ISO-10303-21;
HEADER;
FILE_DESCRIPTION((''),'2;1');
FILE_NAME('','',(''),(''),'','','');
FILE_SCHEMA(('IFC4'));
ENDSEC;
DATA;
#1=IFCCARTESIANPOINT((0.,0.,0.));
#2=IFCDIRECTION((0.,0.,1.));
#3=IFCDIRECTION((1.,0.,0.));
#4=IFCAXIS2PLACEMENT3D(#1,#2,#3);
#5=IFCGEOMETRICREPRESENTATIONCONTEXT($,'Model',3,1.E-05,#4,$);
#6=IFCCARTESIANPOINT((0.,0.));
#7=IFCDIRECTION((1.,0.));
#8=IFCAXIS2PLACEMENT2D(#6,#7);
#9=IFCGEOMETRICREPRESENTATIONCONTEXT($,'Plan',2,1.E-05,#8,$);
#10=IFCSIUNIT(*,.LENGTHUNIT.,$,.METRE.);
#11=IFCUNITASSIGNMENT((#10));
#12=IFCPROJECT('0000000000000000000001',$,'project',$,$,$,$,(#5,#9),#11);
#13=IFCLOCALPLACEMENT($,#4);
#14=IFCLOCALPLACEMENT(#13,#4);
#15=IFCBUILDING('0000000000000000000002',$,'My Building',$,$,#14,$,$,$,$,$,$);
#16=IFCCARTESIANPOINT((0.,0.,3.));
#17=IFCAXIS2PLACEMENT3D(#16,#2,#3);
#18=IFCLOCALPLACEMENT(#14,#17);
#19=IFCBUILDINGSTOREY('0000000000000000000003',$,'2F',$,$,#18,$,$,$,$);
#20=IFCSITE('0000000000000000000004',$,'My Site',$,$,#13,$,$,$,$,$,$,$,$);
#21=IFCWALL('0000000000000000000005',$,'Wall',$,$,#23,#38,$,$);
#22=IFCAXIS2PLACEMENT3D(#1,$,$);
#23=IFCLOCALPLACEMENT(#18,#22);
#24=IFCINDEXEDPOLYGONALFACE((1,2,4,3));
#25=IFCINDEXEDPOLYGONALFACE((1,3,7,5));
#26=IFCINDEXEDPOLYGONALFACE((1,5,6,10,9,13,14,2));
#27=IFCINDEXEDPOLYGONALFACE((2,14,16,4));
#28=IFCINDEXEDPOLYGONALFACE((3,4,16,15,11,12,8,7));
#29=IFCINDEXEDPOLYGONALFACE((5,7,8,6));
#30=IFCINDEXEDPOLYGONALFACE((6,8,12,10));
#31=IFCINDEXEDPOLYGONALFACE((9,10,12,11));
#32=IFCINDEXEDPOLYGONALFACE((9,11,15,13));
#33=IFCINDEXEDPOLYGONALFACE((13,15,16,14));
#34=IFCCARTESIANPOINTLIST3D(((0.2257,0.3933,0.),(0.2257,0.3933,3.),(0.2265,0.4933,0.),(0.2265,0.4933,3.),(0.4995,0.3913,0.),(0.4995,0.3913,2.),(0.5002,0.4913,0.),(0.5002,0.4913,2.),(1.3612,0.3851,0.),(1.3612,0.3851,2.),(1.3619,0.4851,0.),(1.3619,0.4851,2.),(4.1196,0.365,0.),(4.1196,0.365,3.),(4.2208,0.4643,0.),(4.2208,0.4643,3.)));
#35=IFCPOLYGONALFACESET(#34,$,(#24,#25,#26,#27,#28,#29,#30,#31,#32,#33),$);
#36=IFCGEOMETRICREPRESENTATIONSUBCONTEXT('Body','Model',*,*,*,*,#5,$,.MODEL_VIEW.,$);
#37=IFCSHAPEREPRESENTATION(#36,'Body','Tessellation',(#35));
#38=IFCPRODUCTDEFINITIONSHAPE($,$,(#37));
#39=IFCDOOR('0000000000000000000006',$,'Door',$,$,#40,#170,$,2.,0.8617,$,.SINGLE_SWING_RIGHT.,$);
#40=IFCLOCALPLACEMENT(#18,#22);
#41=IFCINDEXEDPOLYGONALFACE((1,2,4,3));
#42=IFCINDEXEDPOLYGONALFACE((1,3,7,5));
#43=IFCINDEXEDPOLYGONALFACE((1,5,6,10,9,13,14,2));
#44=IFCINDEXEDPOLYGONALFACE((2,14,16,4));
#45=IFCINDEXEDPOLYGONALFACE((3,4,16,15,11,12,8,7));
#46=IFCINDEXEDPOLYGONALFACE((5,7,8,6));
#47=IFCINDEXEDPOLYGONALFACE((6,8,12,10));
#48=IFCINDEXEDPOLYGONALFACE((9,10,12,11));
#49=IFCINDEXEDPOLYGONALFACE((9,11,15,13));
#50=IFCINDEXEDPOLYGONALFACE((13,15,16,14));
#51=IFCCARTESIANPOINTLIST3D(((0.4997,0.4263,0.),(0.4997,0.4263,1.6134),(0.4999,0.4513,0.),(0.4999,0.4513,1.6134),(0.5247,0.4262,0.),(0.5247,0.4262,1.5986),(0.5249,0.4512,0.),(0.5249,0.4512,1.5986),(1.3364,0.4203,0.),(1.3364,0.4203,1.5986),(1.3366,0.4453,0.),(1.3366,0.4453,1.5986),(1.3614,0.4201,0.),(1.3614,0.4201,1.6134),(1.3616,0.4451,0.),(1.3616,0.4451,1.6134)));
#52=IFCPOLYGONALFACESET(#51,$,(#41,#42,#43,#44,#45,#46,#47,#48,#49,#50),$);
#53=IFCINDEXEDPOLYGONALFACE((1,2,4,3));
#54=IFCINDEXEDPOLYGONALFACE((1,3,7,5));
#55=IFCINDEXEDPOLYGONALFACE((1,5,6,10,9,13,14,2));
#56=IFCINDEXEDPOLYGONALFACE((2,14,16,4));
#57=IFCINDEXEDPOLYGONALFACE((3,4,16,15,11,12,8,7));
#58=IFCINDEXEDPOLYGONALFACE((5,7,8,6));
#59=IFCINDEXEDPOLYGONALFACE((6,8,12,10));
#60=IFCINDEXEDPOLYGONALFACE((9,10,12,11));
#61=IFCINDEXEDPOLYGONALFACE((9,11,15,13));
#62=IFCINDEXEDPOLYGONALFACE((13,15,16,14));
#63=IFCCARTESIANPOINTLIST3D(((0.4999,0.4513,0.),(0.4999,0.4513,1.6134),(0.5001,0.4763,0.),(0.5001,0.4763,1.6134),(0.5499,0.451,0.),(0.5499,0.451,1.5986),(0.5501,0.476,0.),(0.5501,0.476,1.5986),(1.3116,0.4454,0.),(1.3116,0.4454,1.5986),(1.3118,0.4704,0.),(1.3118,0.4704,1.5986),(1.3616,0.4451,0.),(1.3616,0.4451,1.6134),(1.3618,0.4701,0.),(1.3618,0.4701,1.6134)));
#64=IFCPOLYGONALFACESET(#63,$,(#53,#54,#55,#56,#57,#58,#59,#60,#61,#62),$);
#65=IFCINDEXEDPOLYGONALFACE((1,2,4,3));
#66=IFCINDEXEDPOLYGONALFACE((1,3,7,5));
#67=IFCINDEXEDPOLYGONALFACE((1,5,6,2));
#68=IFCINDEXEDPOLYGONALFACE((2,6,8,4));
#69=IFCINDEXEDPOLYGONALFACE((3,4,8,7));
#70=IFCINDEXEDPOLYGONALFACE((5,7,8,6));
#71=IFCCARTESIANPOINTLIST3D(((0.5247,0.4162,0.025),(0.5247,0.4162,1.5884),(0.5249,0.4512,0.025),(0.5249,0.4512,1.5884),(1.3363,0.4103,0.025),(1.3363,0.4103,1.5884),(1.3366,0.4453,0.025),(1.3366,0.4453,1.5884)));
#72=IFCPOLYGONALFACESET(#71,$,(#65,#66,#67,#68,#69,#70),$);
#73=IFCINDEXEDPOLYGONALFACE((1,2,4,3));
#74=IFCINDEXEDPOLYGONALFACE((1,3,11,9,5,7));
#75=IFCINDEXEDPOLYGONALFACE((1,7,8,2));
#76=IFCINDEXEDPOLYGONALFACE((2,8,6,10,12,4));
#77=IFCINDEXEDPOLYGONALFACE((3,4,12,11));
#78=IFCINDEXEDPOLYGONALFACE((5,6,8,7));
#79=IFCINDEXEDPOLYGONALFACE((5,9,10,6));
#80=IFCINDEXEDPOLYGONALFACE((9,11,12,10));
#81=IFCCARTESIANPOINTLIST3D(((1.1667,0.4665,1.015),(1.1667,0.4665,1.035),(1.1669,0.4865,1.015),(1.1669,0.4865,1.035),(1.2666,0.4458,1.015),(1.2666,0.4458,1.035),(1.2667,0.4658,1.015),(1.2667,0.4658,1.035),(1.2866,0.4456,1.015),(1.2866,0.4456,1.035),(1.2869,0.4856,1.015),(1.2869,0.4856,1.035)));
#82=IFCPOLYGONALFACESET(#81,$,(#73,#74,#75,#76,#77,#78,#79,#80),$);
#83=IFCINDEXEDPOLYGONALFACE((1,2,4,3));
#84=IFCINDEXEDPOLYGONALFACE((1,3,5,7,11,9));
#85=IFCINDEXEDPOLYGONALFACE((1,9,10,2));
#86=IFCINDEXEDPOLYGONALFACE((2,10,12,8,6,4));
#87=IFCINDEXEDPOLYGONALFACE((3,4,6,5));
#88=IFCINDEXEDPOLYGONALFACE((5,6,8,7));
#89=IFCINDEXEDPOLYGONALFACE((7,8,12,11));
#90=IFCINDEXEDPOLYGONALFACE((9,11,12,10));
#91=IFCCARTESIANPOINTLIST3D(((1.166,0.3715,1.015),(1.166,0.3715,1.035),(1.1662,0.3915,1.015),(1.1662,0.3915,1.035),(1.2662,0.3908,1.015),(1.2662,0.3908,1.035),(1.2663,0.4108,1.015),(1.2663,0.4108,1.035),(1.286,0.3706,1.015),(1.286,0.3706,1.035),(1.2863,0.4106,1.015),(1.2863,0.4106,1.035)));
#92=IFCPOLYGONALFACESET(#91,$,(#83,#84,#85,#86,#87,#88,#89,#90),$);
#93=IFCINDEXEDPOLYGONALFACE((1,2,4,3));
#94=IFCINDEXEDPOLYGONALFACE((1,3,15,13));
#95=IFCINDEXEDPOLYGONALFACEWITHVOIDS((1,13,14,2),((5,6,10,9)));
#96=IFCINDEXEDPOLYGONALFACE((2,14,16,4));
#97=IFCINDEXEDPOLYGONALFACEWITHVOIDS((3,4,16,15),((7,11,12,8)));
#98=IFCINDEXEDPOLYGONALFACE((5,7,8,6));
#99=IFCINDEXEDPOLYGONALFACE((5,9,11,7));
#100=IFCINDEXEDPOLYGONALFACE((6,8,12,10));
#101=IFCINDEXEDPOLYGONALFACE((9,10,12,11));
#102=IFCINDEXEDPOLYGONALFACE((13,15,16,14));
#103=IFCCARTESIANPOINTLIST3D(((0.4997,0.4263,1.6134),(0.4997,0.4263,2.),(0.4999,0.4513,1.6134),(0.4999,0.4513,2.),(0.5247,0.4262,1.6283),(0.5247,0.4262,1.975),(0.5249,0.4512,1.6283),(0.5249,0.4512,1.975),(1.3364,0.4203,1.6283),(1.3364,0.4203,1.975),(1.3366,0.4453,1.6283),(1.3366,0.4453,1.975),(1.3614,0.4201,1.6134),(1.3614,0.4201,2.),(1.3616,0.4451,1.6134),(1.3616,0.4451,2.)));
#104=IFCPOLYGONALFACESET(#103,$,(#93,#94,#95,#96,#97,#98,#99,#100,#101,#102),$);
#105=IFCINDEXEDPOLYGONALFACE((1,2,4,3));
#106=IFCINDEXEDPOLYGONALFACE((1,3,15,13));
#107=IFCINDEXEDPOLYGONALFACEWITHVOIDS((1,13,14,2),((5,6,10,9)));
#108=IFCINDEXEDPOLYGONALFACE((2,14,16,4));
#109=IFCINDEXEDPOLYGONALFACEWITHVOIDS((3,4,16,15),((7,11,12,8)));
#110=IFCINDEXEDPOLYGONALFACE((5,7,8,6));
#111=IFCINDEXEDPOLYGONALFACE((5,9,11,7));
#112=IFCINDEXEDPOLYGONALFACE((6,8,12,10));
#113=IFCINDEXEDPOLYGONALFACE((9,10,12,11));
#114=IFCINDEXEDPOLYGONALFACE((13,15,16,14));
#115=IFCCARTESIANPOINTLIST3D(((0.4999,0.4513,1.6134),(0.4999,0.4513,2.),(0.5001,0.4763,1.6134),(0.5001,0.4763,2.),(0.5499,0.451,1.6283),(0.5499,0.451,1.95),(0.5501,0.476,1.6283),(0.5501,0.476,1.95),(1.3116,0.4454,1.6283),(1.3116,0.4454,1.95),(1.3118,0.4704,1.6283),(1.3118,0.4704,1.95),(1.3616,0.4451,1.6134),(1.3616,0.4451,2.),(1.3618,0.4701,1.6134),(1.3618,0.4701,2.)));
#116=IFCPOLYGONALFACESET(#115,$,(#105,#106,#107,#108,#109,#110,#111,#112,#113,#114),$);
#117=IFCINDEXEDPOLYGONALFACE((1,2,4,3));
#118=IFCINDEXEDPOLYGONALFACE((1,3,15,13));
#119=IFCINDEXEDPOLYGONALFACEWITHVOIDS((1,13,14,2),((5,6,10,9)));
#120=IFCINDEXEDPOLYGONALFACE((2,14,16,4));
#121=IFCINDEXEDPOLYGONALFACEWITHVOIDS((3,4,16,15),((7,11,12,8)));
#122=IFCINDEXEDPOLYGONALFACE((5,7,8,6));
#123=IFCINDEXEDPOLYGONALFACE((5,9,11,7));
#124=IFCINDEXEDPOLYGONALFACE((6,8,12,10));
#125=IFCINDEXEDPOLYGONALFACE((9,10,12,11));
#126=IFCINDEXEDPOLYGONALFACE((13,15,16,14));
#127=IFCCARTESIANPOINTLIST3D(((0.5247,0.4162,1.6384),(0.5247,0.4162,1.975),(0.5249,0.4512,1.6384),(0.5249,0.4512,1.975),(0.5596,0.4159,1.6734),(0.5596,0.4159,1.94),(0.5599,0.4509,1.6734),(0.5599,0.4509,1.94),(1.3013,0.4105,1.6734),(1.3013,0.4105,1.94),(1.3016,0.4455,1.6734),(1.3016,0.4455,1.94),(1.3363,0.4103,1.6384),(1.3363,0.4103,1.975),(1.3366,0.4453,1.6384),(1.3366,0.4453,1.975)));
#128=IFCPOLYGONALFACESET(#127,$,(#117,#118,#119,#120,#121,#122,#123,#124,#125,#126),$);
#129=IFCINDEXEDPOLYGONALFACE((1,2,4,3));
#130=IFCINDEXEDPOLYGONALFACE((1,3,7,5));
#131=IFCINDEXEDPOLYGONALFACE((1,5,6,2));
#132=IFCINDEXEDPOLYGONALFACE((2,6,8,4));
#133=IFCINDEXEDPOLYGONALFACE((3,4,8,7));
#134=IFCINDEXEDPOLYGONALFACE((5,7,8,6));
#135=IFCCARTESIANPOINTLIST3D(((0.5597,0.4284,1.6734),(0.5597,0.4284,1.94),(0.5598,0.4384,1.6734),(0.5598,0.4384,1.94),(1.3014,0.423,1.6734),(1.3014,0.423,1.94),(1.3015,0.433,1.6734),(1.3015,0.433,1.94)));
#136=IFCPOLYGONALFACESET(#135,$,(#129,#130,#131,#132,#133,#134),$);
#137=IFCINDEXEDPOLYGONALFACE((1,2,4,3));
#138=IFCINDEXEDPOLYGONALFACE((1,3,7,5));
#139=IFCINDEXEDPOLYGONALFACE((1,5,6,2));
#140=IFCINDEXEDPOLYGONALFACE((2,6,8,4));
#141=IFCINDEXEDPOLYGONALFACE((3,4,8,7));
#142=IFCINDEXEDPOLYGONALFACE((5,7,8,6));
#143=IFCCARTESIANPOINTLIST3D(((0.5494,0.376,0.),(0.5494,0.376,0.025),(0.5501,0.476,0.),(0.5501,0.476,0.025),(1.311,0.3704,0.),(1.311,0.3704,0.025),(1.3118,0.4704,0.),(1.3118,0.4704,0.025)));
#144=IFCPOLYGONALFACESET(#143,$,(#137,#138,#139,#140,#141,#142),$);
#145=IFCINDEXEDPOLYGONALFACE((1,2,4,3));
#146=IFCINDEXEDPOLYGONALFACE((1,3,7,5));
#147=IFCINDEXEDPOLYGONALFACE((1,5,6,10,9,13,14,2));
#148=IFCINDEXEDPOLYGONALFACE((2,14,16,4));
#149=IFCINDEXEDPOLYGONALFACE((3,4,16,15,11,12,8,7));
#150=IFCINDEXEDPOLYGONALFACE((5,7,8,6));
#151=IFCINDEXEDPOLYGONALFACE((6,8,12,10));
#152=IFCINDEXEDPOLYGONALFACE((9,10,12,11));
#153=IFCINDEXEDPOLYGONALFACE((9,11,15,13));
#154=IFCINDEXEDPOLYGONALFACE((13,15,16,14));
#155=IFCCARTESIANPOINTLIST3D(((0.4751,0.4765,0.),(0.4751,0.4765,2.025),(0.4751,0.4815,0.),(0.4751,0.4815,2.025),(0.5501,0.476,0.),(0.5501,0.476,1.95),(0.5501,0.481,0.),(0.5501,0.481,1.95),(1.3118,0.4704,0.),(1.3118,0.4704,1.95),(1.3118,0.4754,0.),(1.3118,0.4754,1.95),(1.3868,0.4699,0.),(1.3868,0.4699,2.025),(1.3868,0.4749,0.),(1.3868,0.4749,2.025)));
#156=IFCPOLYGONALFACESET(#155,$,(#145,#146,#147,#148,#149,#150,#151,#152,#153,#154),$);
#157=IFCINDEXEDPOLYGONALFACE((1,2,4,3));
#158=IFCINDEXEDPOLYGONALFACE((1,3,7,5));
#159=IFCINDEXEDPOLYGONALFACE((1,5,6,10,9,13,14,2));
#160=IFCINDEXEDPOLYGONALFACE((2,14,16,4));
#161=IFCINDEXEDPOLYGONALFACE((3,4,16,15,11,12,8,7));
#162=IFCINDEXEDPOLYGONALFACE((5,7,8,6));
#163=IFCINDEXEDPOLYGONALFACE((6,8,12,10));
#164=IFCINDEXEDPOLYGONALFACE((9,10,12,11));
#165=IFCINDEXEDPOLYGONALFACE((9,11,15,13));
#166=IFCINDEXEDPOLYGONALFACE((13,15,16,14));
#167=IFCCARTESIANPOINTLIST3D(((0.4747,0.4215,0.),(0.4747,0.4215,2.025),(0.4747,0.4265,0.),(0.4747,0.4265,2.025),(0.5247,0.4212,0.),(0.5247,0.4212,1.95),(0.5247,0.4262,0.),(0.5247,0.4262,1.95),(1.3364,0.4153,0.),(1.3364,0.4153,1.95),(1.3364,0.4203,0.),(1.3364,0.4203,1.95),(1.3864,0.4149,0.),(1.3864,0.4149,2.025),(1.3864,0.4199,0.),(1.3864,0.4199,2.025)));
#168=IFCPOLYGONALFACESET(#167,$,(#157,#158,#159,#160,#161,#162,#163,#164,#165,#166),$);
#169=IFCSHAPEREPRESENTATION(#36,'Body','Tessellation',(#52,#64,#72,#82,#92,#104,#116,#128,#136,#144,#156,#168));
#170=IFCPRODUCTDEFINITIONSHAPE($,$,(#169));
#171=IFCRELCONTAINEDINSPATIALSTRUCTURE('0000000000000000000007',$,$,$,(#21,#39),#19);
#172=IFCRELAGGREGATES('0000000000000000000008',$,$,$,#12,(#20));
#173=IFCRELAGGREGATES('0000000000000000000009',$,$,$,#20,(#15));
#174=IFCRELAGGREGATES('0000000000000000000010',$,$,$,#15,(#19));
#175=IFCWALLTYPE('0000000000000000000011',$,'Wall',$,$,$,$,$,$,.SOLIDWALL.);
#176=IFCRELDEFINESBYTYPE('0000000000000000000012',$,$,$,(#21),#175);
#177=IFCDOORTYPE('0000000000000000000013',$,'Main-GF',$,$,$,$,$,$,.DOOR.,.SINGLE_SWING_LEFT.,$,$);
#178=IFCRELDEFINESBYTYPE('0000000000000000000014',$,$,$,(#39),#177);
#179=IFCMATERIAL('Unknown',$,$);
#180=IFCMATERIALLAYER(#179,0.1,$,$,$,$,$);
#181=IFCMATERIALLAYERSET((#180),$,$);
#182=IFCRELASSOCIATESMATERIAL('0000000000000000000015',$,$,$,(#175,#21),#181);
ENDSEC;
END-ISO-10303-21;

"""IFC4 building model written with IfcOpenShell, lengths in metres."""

from ifc_helpers import new_model, entity, si_unit, frame, origin_with_axes, origin_2d_with_axis, place, context, subcontext, project, spatial, line, indexed_curve, outline, extrude, shape, source, transform, mapped, material, layer, layer_set, layer_usage, type_object, type_shapes, element, fill, save


model = new_model("IFC4")

# Units and contexts
model_context = context("Model", 3, precision=1e-05, world=origin_with_axes())
plan_context = context("Plan", 2, precision=1e-05, world=origin_2d_with_axis())
body_context_1 = subcontext(model_context, "Body", "Model", "MODEL_VIEW")
body_context_2 = subcontext(plan_context, "Body", "Plan", "PLAN_VIEW")
ifc_project = project(units=[si_unit("LENGTHUNIT", "METRE")], contexts=[model_context, plan_context])

# Site, building, storey
site_placement = place(None, origin_with_axes())
site = spatial("IfcSite", under=ifc_project, at=site_placement, Name="My Site")
building_placement = place(site_placement, origin_with_axes())
building = spatial("IfcBuilding", under=site, at=building_placement, Name="My Building")
storey_placement = place(building_placement, frame((0.0, 0.0, 3.0), z_axis=(0.0, 0.0, 1.0), x_axis=(1.0, 0.0, 0.0)))
storey = spatial("IfcBuildingStorey", under=building, at=storey_placement, Name="2F")

# Shared definitions
ifc_material = material(Name="Unknown")
ifc_layer = layer(ifc_material, 0.1)
ifc_layer_set = layer_set([ifc_layer])
wall_type = type_object("IfcWallType", Name="Wall", PredefinedType="SOLIDWALL", material=ifc_layer_set)

# Wall, opening, door
ifc_layer_usage_1 = layer_usage(ifc_layer_set, "AXIS2", "POSITIVE", 0.0)
wall_1_placement = place(storey_placement, frame((0.2257, 0.3933, 0.0), z_axis=(0.0, 0.0, 1.0), x_axis=(0.999974, -0.007275, 0.0)))
wall_1 = element("IfcWall", 1, at=wall_1_placement, inside=storey, type_object=wall_type, material=ifc_layer_usage_1, Name="Wall", context=body_context_1, shape_type="SweptSolid", body=[
    extrude(outline(indexed_curve([(0.0, 0.0), (0.0, 0.1), (3.9944, 0.1), (3.894, 0.0)], segments=[line(1, 2, 3, 4, 1)])), origin_with_axes(), (0.0, 0.0, 1.0), 3.0),
])
shared_shape_1 = source(origin_with_axes(), body_context_1, "Body", "SweptSolid", [
    extrude(outline(indexed_curve([(0.0, 0.0), (0.8617, 0.0), (0.8617, 2.0), (0.0, 2.0)], segments=[line(1, 2, 3, 4, 1)])), frame((0.0, -0.6, 0.0), z_axis=(0.0, -1.0, 0.0), x_axis=(1.0, 0.0, 0.0)), (0.0, 0.0, -1.0), 1.2),
])
opening_1_placement = place(wall_1_placement, frame((1.1354, 0.085, 0.0), z_axis=(0.0, 0.0, 1.0), x_axis=(-1.0, 0.0, 0.0)))
opening_1 = element("IfcOpeningElement", 2, at=opening_1_placement, cuts=wall_1, PredefinedType="OPENING", context=body_context_1, shape_type="MappedRepresentation", body=[
    mapped(shared_shape_1, transform((0.0, 0.0, 0.0), x_axis=(1.0, 0.0, 0.0), y_axis=(0.0, 1.0, 0.0), z_axis=(0.0, 0.0, 1.0), scale=1.0)),
])
door_type_1 = type_object("IfcDoorType", Name="Main-GF", OperationType="SINGLE_SWING_LEFT", PredefinedType="DOOR")
shared_shape_2 = source(origin_with_axes(), body_context_1, "Body", "SweptSolid", [
    extrude(outline(indexed_curve([(0.0, 0.0), (0.0, 1.6134), (0.8617, 1.6134), (0.8617, 0.0), (0.8367, 0.0), (0.8367, 1.5986), (0.025, 1.5986), (0.025, 0.0)], segments=[line(1, 2, 3, 4, 5, 6, 7, 8, 1)])), frame((0.0, 0.025, 0.0), z_axis=(0.0, -1.0, 0.0), x_axis=(1.0, 0.0, 0.0)), (0.0, 0.0, -1.0), 0.025),
    extrude(outline(indexed_curve([(0.0, 0.0), (0.0, 1.6134), (0.8617, 1.6134), (0.8617, 0.0), (0.8117, 0.0), (0.8117, 1.5986), (0.05, 1.5986), (0.05, 0.0)], segments=[line(1, 2, 3, 4, 5, 6, 7, 8, 1)])), frame((0.0, 0.0, 0.0), z_axis=(0.0, -1.0, 0.0), x_axis=(1.0, 0.0, 0.0)), (0.0, 0.0, -1.0), 0.025),
    extrude(outline(indexed_curve([(0.0, 0.0), (0.8117, 0.0), (0.8117, 0.035), (0.0, 0.035)], segments=[line(1, 2, 3, 4, 1)])), frame((0.025, 0.025, 0.025), z_axis=(0.0, 0.0, 1.0), x_axis=(1.0, 0.0, 0.0)), (0.0, 0.0, 1.0), 1.5634),
    extrude(outline(indexed_curve([(0.0, 0.0), (0.0, -0.04), (0.12, -0.04), (0.12, -0.02), (0.02, -0.02), (0.02, 0.0)], segments=[line(1, 2, 3, 4, 5, 6, 1)])), frame((0.075, 0.025, 1.015), z_axis=(0.0, 0.0, 1.0), x_axis=(1.0, 0.0, 0.0)), (0.0, 0.0, 1.0), 0.02),
    extrude(outline(indexed_curve([(0.0, 0.0), (0.0, 0.04), (0.12, 0.04), (0.12, 0.02), (0.02, 0.02), (0.02, 0.0)], segments=[line(1, 2, 3, 4, 5, 6, 1)])), frame((0.075, 0.06, 1.015), z_axis=(0.0, 0.0, 1.0), x_axis=(1.0, 0.0, 0.0)), (0.0, 0.0, 1.0), 0.02),
    extrude(outline(indexed_curve([(0.0, 0.0), (0.8617, 0.0), (0.8617, 0.3866), (0.0, 0.3866)], segments=[line(1, 2, 3, 4, 1)]), holes=[indexed_curve([(0.025, 0.0148), (0.8367, 0.0148), (0.8367, 0.3616), (0.025, 0.3616)], segments=[line(1, 2, 3, 4, 1)])]), frame((0.0, 0.025, 1.6134), z_axis=(0.0, -1.0, 0.0), x_axis=(1.0, 0.0, 0.0)), (0.0, 0.0, -1.0), 0.025),
    extrude(outline(indexed_curve([(0.0, 0.0), (0.8617, 0.0), (0.8617, 0.3866), (0.0, 0.3866)], segments=[line(1, 2, 3, 4, 1)]), holes=[indexed_curve([(0.05, 0.0148), (0.8117, 0.0148), (0.8117, 0.3366), (0.05, 0.3366)], segments=[line(1, 2, 3, 4, 1)])]), frame((0.0, 0.0, 1.6134), z_axis=(0.0, -1.0, 0.0), x_axis=(1.0, 0.0, 0.0)), (0.0, 0.0, -1.0), 0.025),
    extrude(outline(indexed_curve([(0.0, 0.0), (0.8117, 0.0), (0.8117, 0.3366), (0.0, 0.3366)], segments=[line(1, 2, 3, 4, 1)]), holes=[indexed_curve([(0.035, 0.035), (0.7767, 0.035), (0.7767, 0.3016), (0.035, 0.3016)], segments=[line(1, 2, 3, 4, 1)])]), frame((0.025, 0.025, 1.6384), z_axis=(0.0, -1.0, 0.0), x_axis=(1.0, 0.0, 0.0)), (0.0, 0.0, -1.0), 0.035),
    extrude(outline(indexed_curve([(0.035, 0.035), (0.7767, 0.035), (0.7767, 0.3016), (0.035, 0.3016)], segments=[line(1, 2, 3, 4, 1)])), frame((0.025, 0.0375, 1.6384), z_axis=(0.0, -1.0, 0.0), x_axis=(1.0, 0.0, 0.0)), (0.0, 0.0, -1.0), 0.01),
    extrude(outline(indexed_curve([(0.0, 0.0), (0.7617, 0.0), (0.7617, 0.1), (0.0, 0.1)], segments=[line(1, 2, 3, 4, 1)])), frame((0.05, 0.0, 0.0), z_axis=(0.0, 0.0, 1.0), x_axis=(1.0, 0.0, 0.0)), (0.0, 0.0, 1.0), 0.025),
    extrude(outline(indexed_curve([(0.0, 0.0), (0.0, 2.025), (0.9117, 2.025), (0.9117, 0.0), (0.8367, 0.0), (0.8367, 1.95), (0.075, 1.95), (0.075, 0.0)], segments=[line(1, 2, 3, 4, 5, 6, 7, 8, 1)])), frame((-0.025, -0.005, 0.0), z_axis=(0.0, -1.0, 0.0), x_axis=(1.0, 0.0, 0.0)), (0.0, 0.0, -1.0), 0.005),
    extrude(outline(indexed_curve([(0.0, 0.0), (0.0, 2.025), (0.9117, 2.025), (0.9117, 0.0), (0.8617, 0.0), (0.8617, 1.95), (0.05, 1.95), (0.05, 0.0)], segments=[line(1, 2, 3, 4, 5, 6, 7, 8, 1)])), frame((-0.025, 0.05, 0.0), z_axis=(0.0, -1.0, 0.0), x_axis=(1.0, 0.0, 0.0)), (0.0, 0.0, -1.0), 0.005),
])
shared_shape_3 = source(origin_with_axes(), body_context_2, "Body", "Curve2D", [
    entity("IfcIndexedPolyCurve", entity("IfcCartesianPointList2D", [[0.0, 0.0], [0.0, 0.05], [0.025, 0.05], [0.025, 0.025], [0.05, 0.025], [0.05, 0.0]]), [entity("IfcLineIndex", [1, 2, 3, 4, 5, 6, 1])]),
    entity("IfcIndexedPolyCurve", entity("IfcCartesianPointList2D", [[0.8617, 0.0], [0.8617, 0.05], [0.8367, 0.05], [0.8367, 0.025], [0.8117, 0.025], [0.8117, 0.0]]), [entity("IfcLineIndex", [1, 2, 3, 4, 5, 6, 1])]),
    entity("IfcTrimmedCurve", entity("IfcEllipse", entity("IfcAxis2Placement2D", entity("IfcCartesianPoint", [0.8017, 0.05]), entity("IfcDirection", [1.0, 0.0])), 0.7767, 0.8117), [entity("IfcCartesianPoint", [0.8017, 0.8617])], [entity("IfcCartesianPoint", [0.025, 0.05])], True, "CARTESIAN"),
    entity("IfcIndexedPolyCurve", entity("IfcCartesianPointList2D", [[0.8367, 0.05], [0.8017, 0.05], [0.8017, 0.8617], [0.8367, 0.8617]]), [entity("IfcLineIndex", [1, 2, 3, 4, 1])]),
])
type_shapes(door_type_1, [shared_shape_2, shared_shape_3])
door_1_placement = place(opening_1_placement, frame((0.0, 0.0, 0.0), z_axis=(0.0, 0.0, 1.0), x_axis=(1.0, 0.0, 0.0)))
door_1 = element("IfcDoor", 3, at=door_1_placement, inside=storey, type_object=door_type_1, Name="Door", OperationType="SINGLE_SWING_RIGHT", OverallHeight=2.0, OverallWidth=0.8617, shapes=[
    shape(body_context_1, "Body", "MappedRepresentation", [mapped(shared_shape_2, transform((0.0, 0.0, 0.0), x_axis=(1.0, 0.0, 0.0), y_axis=(0.0, 1.0, 0.0), z_axis=(0.0, 0.0, 1.0), scale=1.0))]),
    shape(body_context_2, "Body", "MappedRepresentation", [mapped(shared_shape_3, transform((0.0, 0.0, 0.0), x_axis=(1.0, 0.0, 0.0), y_axis=(0.0, 1.0, 0.0), z_axis=(0.0, 0.0, 1.0), scale=1.0))]),
])
fill(opening_1, door_1)

save(model, "model.ifc")
